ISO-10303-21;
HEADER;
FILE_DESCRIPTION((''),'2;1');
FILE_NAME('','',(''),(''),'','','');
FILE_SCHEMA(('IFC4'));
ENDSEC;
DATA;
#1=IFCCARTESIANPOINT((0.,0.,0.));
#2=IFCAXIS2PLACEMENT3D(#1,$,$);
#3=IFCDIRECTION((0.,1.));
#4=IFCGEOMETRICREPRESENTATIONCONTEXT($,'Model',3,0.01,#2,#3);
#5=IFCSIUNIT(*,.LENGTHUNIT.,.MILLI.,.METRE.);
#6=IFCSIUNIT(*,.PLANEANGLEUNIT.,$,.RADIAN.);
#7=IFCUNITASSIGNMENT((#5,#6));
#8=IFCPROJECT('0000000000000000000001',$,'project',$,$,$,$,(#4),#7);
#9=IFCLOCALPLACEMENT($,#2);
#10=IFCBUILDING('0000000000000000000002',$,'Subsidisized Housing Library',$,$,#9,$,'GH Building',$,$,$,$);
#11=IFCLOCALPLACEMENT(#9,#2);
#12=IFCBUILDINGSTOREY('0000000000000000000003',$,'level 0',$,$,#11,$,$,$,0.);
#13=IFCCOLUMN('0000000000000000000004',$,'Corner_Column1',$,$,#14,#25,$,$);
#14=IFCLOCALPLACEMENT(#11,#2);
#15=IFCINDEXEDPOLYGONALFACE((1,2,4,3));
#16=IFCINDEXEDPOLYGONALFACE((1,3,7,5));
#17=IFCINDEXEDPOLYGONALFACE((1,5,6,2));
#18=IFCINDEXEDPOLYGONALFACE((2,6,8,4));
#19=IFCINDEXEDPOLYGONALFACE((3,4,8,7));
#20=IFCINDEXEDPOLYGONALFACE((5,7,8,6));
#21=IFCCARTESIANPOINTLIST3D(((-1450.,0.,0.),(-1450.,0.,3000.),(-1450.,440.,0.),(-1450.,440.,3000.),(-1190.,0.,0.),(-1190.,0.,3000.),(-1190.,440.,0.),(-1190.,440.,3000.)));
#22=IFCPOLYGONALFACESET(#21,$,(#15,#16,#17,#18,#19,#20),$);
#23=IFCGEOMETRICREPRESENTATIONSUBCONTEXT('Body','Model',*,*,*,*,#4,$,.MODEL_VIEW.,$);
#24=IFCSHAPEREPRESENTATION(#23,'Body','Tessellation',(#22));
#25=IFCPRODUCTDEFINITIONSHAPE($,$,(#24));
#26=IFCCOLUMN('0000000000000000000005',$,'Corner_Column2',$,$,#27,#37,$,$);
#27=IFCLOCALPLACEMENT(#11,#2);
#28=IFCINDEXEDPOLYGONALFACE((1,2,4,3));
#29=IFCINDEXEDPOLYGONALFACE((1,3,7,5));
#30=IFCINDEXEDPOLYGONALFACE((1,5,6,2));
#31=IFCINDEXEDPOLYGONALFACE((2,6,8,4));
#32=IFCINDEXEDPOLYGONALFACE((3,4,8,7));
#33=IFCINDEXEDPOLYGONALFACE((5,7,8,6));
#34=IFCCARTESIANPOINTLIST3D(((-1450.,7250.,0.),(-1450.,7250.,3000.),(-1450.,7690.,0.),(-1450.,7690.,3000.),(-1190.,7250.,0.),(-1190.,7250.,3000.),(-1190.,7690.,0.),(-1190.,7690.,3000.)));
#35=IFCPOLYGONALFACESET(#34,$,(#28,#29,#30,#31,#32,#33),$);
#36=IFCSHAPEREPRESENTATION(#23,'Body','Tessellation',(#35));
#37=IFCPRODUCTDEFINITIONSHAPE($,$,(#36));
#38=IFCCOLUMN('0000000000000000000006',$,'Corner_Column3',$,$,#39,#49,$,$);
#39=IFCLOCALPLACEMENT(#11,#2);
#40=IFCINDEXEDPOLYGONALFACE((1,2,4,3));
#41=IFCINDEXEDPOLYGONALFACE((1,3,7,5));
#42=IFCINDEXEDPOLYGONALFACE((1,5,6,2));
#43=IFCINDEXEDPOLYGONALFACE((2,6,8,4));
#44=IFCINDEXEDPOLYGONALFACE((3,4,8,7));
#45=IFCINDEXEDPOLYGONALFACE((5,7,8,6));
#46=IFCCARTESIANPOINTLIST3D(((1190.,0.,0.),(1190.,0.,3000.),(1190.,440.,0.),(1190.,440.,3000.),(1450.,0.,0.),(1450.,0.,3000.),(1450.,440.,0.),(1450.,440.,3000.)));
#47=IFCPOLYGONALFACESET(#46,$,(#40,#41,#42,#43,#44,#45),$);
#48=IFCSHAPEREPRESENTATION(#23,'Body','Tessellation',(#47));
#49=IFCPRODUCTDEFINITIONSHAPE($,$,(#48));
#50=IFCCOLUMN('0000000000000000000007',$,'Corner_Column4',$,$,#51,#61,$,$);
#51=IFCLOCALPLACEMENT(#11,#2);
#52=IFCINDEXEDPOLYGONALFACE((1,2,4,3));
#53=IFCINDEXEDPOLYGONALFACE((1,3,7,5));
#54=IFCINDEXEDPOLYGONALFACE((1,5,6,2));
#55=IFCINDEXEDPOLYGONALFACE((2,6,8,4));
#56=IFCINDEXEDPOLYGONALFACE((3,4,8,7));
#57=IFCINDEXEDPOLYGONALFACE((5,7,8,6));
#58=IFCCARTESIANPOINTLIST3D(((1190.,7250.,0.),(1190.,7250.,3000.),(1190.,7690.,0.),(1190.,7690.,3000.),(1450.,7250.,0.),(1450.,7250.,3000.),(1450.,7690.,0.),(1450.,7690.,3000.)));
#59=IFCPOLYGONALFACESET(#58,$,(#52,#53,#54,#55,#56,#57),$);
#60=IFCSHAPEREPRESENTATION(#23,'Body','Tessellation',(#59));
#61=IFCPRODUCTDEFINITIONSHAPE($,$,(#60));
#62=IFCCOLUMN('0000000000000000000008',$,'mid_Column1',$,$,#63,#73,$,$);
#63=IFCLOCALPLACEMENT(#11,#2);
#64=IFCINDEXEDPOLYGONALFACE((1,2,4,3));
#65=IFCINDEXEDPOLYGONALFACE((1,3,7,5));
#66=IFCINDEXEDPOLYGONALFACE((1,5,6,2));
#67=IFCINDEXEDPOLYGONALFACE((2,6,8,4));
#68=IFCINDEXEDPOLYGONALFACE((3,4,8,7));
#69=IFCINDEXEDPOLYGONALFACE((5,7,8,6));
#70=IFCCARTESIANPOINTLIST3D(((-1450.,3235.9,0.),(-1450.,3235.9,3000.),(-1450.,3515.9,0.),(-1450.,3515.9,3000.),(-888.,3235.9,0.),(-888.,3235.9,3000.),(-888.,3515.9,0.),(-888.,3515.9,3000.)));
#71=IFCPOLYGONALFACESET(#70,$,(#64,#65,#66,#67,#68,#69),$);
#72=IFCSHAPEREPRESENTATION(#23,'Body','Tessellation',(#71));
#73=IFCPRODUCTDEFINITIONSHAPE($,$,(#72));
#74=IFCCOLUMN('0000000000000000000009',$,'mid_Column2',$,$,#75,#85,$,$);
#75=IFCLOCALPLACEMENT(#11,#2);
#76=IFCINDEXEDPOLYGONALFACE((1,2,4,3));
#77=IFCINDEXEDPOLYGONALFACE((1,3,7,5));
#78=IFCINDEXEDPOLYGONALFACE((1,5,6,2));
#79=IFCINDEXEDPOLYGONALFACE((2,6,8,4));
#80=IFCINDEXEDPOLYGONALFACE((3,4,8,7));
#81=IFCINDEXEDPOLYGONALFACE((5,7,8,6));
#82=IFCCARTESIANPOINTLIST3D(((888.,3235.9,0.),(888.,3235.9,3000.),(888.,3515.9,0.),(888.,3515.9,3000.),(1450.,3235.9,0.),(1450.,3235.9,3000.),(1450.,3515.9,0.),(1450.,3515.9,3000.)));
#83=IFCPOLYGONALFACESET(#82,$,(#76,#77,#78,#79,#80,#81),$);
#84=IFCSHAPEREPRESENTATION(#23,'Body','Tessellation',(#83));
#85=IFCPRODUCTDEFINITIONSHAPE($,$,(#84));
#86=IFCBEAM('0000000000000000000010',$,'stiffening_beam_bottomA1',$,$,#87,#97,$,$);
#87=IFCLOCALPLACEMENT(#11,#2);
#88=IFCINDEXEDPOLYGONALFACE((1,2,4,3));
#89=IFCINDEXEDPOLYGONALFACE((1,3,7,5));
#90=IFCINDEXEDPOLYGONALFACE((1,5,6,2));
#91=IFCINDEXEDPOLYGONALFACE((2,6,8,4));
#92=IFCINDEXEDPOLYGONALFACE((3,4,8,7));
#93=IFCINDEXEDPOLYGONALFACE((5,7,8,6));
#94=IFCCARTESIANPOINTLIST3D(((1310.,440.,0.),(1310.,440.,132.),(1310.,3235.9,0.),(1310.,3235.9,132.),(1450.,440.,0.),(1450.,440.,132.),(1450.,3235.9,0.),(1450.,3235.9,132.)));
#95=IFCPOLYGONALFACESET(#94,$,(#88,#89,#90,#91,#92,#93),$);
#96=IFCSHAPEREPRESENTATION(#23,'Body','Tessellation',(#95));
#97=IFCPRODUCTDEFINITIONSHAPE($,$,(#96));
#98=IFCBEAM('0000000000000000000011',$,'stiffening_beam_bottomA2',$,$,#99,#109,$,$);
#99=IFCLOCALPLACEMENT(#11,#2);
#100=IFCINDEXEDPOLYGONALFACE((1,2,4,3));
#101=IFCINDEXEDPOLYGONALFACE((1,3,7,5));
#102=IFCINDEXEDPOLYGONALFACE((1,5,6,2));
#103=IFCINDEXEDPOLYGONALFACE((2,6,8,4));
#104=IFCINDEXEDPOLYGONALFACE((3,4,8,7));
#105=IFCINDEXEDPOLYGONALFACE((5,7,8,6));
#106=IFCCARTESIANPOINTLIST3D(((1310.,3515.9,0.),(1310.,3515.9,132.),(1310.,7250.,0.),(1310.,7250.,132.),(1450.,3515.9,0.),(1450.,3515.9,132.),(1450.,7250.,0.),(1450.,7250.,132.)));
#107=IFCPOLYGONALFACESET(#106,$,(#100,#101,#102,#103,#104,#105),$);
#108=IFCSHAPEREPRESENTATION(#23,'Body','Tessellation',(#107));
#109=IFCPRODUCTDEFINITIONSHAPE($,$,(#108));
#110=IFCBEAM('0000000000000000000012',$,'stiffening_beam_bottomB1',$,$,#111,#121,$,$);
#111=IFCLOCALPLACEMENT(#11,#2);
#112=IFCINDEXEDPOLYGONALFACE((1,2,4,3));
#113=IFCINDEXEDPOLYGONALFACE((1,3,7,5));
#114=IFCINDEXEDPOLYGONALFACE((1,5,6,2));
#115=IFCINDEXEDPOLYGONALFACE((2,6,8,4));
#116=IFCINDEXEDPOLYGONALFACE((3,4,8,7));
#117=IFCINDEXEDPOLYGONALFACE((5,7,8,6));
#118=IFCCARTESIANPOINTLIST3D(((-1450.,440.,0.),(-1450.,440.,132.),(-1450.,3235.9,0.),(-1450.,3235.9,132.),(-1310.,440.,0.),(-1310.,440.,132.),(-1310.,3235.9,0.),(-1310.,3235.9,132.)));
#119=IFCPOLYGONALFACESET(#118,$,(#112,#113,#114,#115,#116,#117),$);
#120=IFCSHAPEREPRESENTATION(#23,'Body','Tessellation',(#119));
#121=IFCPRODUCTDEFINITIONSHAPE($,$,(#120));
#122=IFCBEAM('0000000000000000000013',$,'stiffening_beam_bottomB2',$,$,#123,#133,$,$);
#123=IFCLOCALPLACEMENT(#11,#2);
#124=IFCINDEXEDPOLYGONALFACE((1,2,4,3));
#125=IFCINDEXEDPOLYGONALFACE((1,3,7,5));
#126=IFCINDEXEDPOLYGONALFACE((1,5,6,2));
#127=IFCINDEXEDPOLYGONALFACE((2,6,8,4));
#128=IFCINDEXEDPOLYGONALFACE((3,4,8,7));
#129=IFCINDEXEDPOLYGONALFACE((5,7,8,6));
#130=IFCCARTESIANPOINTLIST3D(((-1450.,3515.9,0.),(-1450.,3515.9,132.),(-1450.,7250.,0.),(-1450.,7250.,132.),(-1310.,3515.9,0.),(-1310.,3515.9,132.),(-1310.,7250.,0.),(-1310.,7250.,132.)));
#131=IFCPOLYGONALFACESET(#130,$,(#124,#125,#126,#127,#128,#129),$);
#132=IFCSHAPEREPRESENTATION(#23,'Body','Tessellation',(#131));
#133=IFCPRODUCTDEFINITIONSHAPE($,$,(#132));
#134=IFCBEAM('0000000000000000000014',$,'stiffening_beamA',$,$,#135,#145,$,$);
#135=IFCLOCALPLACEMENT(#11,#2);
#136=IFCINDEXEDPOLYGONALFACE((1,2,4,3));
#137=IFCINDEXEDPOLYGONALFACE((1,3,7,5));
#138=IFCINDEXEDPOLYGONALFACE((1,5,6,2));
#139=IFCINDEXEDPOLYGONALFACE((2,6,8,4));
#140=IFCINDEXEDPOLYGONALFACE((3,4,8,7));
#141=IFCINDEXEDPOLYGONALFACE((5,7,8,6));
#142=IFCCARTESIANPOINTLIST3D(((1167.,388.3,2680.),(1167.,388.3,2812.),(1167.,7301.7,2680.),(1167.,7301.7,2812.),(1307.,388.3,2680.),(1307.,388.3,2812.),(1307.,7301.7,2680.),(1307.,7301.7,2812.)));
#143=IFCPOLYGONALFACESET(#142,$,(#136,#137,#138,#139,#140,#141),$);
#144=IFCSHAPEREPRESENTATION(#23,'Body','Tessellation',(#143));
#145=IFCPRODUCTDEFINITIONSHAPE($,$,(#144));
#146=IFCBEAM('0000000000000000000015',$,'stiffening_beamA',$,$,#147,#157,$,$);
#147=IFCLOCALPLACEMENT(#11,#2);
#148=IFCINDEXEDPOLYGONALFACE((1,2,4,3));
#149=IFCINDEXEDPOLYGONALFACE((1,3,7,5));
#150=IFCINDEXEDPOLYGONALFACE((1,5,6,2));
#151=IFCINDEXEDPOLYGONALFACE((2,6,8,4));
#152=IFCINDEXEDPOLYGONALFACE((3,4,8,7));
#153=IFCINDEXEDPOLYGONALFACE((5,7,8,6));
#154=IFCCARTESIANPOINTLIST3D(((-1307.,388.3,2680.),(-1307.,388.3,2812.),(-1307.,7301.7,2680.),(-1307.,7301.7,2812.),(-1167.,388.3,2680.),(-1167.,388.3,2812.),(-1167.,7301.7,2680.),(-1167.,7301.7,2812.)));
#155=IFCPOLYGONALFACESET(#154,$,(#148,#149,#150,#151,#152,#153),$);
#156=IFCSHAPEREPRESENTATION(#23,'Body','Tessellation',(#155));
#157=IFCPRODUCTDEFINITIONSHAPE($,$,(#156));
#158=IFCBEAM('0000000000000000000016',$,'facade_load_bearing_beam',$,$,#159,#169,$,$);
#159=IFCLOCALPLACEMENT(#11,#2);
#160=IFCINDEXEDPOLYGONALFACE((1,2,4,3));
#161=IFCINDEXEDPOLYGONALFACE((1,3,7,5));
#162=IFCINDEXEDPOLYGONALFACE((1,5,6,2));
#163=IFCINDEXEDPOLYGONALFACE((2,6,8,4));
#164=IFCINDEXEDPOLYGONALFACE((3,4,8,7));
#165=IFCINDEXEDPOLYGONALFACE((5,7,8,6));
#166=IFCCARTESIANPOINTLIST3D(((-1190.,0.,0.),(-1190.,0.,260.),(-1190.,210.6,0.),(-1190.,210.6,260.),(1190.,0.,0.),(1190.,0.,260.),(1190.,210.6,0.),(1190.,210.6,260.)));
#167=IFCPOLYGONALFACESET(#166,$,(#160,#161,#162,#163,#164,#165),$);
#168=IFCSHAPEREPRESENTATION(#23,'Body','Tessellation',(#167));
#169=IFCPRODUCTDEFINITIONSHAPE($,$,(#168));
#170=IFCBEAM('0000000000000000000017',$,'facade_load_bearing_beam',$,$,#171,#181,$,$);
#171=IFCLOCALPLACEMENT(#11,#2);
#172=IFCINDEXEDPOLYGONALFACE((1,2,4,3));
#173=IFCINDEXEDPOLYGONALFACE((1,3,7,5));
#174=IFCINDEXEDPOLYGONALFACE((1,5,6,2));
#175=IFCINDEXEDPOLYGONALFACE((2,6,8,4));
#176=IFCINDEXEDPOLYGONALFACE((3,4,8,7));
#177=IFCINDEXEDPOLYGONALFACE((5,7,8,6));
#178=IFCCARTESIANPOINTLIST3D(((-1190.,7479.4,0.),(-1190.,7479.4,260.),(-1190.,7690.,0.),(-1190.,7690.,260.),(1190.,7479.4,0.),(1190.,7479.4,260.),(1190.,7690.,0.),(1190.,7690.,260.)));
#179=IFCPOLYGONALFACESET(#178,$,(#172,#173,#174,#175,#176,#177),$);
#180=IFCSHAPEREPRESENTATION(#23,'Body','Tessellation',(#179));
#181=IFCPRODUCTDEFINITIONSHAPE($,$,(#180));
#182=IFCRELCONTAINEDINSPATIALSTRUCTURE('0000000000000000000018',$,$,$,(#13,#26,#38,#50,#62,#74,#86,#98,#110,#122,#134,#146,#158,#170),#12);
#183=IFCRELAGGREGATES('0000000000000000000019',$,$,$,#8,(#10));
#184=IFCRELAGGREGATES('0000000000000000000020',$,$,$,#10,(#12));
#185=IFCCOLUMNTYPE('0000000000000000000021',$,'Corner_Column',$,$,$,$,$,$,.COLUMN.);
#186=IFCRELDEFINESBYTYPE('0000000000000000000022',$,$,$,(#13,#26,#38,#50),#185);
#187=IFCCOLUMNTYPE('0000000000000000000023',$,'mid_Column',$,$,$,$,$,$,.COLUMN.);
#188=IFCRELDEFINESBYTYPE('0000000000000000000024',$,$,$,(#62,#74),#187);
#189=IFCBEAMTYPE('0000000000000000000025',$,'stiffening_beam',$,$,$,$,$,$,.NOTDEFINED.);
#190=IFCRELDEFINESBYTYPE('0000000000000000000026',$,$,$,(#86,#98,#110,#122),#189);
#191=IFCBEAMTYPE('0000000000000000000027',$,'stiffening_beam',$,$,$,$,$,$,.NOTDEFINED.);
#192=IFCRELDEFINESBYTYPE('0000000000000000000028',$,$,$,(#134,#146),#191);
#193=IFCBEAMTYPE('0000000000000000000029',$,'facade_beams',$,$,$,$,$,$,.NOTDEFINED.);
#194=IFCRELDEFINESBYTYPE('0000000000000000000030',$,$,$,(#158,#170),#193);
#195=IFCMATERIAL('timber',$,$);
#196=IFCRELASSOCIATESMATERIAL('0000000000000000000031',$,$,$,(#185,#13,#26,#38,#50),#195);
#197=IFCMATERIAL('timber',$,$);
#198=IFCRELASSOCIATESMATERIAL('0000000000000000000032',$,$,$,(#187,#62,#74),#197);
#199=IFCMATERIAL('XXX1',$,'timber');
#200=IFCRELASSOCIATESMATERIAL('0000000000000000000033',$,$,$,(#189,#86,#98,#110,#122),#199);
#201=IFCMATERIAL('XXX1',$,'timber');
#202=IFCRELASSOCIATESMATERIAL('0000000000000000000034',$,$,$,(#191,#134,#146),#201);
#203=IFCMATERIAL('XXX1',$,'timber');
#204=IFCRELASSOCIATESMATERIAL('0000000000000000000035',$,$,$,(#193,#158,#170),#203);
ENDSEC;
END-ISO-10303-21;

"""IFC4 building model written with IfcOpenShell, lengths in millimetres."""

from ifc_helpers import new_model, si_unit, direction, frame, frame_2d, origin, place, context, subcontext, project, spatial, rectangle, extrude, material, material_profile, profile_set, profile_usage, type_object, element, save


model = new_model("IFC4")

# Units and contexts
model_context = context("Model", 3, precision=0.01, world=origin(), true_north=direction((0.0, 1.0)))
body_context = subcontext(model_context, "Body", "Model", "MODEL_VIEW")
ifc_project = project(units=[si_unit("LENGTHUNIT", "METRE", prefix="MILLI"), si_unit("PLANEANGLEUNIT", "RADIAN")], contexts=[model_context])

# Building, storey
building_placement = place(None, origin())
building = spatial("IfcBuilding", under=ifc_project, at=building_placement, Name="Subsidisized Housing Library", LongName="GH Building")
storey_placement = place(building_placement, origin())
storey = spatial("IfcBuildingStorey", under=building, at=storey_placement, Name="level 0", Elevation=0.0)

# Columns
ifc_material_1 = material(Name="timber")
ifc_material_profile_1 = material_profile(ifc_material_1, rectangle(XDim=260.0, YDim=440.0), Name="timberProfileXX", Priority=0)
ifc_profile_set_1 = profile_set([ifc_material_profile_1], Name="Corner_Column")
ifc_profile_usage_1 = profile_usage(ifc_profile_set_1, cardinal=5)
column_type_1 = type_object("IfcColumnType", Name="Corner_Column", PredefinedType="COLUMN", material=ifc_profile_set_1)
for number, where, name in (
    (1, (-1320.0, 220.0, 0.0), "Corner_Column1"),
    (2, (-1320.0, 7470.0, 0.0), "Corner_Column2"),
    (3, (1320.0, 220.0, 0.0), "Corner_Column3"),
    (4, (1320.0, 7470.0, 0.0), "Corner_Column4"),
):
    element("IfcColumn", number, at=place(storey_placement, frame(where)), inside=storey, type_object=column_type_1, material=ifc_profile_usage_1, Name=name, context=body_context, shape_type="AdvancedSweptSolid", body=[
        extrude(rectangle(XDim=260.0, YDim=440.0), None, (0.0, 0.0, 1.0), 3000.0),
    ])
ifc_material_2 = material(Name="timber")
ifc_material_profile_2 = material_profile(ifc_material_2, rectangle(XDim=562.0, YDim=280.0), Name="timberProfileXX", Priority=0)
ifc_profile_set_2 = profile_set([ifc_material_profile_2], Name="mid_Column")
ifc_profile_usage_2 = profile_usage(ifc_profile_set_2, cardinal=6)
column_type_2 = type_object("IfcColumnType", Name="mid_Column", PredefinedType="COLUMN", material=ifc_profile_set_2)
column_1_placement = place(storey_placement, frame((-1450.0, 3375.9, 0.0)))
element("IfcColumn", 5, at=column_1_placement, inside=storey, type_object=column_type_2, material=ifc_profile_usage_2, Name="mid_Column1", context=body_context, shape_type="AdvancedSweptSolid", body=[
    extrude(rectangle(XDim=562.0, YDim=280.0), frame((281.0, 0.0, 0.0)), (0.0, 0.0, 1.0), 3000.0),
])
ifc_profile_usage_3 = profile_usage(ifc_profile_set_2, cardinal=4)
column_2_placement = place(storey_placement, frame((1450.0, 3375.9, 0.0)))
element("IfcColumn", 6, at=column_2_placement, inside=storey, type_object=column_type_2, material=ifc_profile_usage_3, Name="mid_Column2", context=body_context, shape_type="AdvancedSweptSolid", body=[
    extrude(rectangle(XDim=562.0, YDim=280.0), frame((-281.0, 0.0, 0.0)), (0.0, 0.0, 1.0), 3000.0),
])

# Beams
ifc_material_3 = material(Name="XXX1", Category="timber")
ifc_material_profile_3 = material_profile(ifc_material_3, rectangle(XDim=140.0, YDim=132.0), Name="impleniaMaterialA", Priority=0)
ifc_profile_set_3 = profile_set([ifc_material_profile_3], Name="stiffening_beam")
ifc_profile_usage_4 = profile_usage(ifc_profile_set_3, cardinal=3)
beam_type_1 = type_object("IfcBeamType", Name="stiffening_beam", PredefinedType="NOTDEFINED", material=ifc_profile_set_3)
beam_1_placement = place(storey_placement, frame((1450.0, 440.0, 0.0), z_axis=(0.0, 1.0, 0.0), x_axis=(-1.0, 0.0, 0.0)))
element("IfcBeam", 7, at=beam_1_placement, inside=storey, type_object=beam_type_1, material=ifc_profile_usage_4, Name="stiffening_beam_bottomA1", context=body_context, shape_type="AdvancedSweptSolid", body=[
    extrude(rectangle(XDim=140.0, YDim=132.0), frame((70.0, 66.0, 0.0)), (0.0, 0.0, 1.0), 2795.9),
])
beam_2_placement = place(storey_placement, frame((1450.0, 3515.9, 0.0), z_axis=(0.0, 1.0, 0.0), x_axis=(-1.0, 0.0, 0.0)))
element("IfcBeam", 8, at=beam_2_placement, inside=storey, type_object=beam_type_1, material=ifc_profile_usage_4, Name="stiffening_beam_bottomA2", context=body_context, shape_type="AdvancedSweptSolid", body=[
    extrude(rectangle(XDim=140.0, YDim=132.0), frame((70.0, 66.0, 0.0)), (0.0, 0.0, 1.0), 3734.1),
])
ifc_profile_usage_5 = profile_usage(ifc_profile_set_3, cardinal=1)
beam_3_placement = place(storey_placement, frame((-1450.0, 440.0, 0.0), z_axis=(0.0, 1.0, 0.0), x_axis=(-1.0, 0.0, 0.0)))
element("IfcBeam", 9, at=beam_3_placement, inside=storey, type_object=beam_type_1, material=ifc_profile_usage_5, Name="stiffening_beam_bottomB1", context=body_context, shape_type="AdvancedSweptSolid", body=[
    extrude(rectangle(XDim=140.0, YDim=132.0), frame((-70.0, 66.0, 0.0)), (0.0, 0.0, 1.0), 2795.9),
])
beam_4_placement = place(storey_placement, frame((-1450.0, 3515.9, 0.0), z_axis=(0.0, 1.0, 0.0), x_axis=(-1.0, 0.0, 0.0)))
element("IfcBeam", 10, at=beam_4_placement, inside=storey, type_object=beam_type_1, material=ifc_profile_usage_5, Name="stiffening_beam_bottomB2", context=body_context, shape_type="AdvancedSweptSolid", body=[
    extrude(rectangle(XDim=140.0, YDim=132.0), frame((-70.0, 66.0, 0.0)), (0.0, 0.0, 1.0), 3734.1),
])
ifc_material_4 = material(Name="XXX1", Category="timber")
ifc_material_profile_4 = material_profile(ifc_material_4, rectangle(XDim=140.0, YDim=132.0), Name="impleniaMaterialA", Priority=0)
ifc_profile_set_4 = profile_set([ifc_material_profile_4], Name="stiffening_beam")
ifc_profile_usage_6 = profile_usage(ifc_profile_set_4, cardinal=1)
beam_type_2 = type_object("IfcBeamType", Name="stiffening_beam", PredefinedType="NOTDEFINED", material=ifc_profile_set_4)
beam_5_placement = place(storey_placement, frame((1167.0, 388.3, 2680.0), z_axis=(0.0, 1.0, 0.0), x_axis=(-1.0, 0.0, 0.0)))
element("IfcBeam", 11, at=beam_5_placement, inside=storey, type_object=beam_type_2, material=ifc_profile_usage_6, Name="stiffening_beamA", context=body_context, shape_type="AdvancedSweptSolid", body=[
    extrude(rectangle(XDim=140.0, YDim=132.0), frame((-70.0, 66.0, 0.0)), (0.0, 0.0, 1.0), 6913.3),
])
ifc_profile_usage_7 = profile_usage(ifc_profile_set_4, cardinal=3)
beam_6_placement = place(storey_placement, frame((-1167.0, 388.3, 2680.0), z_axis=(0.0, 1.0, 0.0), x_axis=(-1.0, 0.0, 0.0)))
element("IfcBeam", 12, at=beam_6_placement, inside=storey, type_object=beam_type_2, material=ifc_profile_usage_7, Name="stiffening_beamA", context=body_context, shape_type="AdvancedSweptSolid", body=[
    extrude(rectangle(XDim=140.0, YDim=132.0), frame((70.0, 66.0, 0.0)), (0.0, 0.0, 1.0), 6913.3),
])
ifc_material_5 = material(Name="XXX1", Category="timber")
ifc_material_profile_5 = material_profile(ifc_material_5, rectangle(XDim=210.6, YDim=260.0, at=frame_2d((105.3, 130.0))), Name="impleniaMaterialA", Priority=0)
ifc_profile_set_5 = profile_set([ifc_material_profile_5], Name="facade_beams")
ifc_profile_usage_8 = profile_usage(ifc_profile_set_5, cardinal=3)
beam_type_3 = type_object("IfcBeamType", Name="facade_beams", PredefinedType="NOTDEFINED", material=ifc_profile_set_5)
for number, where, z_axis, x_axis, name in (
    (13, (-1190.0, 0.0, 0.0), (1.0, 0.0, 0.0), (0.0, 1.0, 0.0), "facade_load_bearing_beam"),
    (14, (1190.0, 7690.0, 0.0), (-1.0, 0.0, 0.0), (0.0, -1.0, 0.0), "facade_load_bearing_beam"),
):
    element("IfcBeam", number, at=place(storey_placement, frame(where, z_axis=z_axis, x_axis=x_axis)), inside=storey, type_object=beam_type_3, material=ifc_profile_usage_8, Name=name, context=body_context, shape_type="AdvancedSweptSolid", body=[
        extrude(rectangle(XDim=210.6, YDim=260.0, at=frame_2d((105.3, 130.0))), None, (0.0, 0.0, 1.0), 2380.0),
    ])

save(model, "model.ifc")
